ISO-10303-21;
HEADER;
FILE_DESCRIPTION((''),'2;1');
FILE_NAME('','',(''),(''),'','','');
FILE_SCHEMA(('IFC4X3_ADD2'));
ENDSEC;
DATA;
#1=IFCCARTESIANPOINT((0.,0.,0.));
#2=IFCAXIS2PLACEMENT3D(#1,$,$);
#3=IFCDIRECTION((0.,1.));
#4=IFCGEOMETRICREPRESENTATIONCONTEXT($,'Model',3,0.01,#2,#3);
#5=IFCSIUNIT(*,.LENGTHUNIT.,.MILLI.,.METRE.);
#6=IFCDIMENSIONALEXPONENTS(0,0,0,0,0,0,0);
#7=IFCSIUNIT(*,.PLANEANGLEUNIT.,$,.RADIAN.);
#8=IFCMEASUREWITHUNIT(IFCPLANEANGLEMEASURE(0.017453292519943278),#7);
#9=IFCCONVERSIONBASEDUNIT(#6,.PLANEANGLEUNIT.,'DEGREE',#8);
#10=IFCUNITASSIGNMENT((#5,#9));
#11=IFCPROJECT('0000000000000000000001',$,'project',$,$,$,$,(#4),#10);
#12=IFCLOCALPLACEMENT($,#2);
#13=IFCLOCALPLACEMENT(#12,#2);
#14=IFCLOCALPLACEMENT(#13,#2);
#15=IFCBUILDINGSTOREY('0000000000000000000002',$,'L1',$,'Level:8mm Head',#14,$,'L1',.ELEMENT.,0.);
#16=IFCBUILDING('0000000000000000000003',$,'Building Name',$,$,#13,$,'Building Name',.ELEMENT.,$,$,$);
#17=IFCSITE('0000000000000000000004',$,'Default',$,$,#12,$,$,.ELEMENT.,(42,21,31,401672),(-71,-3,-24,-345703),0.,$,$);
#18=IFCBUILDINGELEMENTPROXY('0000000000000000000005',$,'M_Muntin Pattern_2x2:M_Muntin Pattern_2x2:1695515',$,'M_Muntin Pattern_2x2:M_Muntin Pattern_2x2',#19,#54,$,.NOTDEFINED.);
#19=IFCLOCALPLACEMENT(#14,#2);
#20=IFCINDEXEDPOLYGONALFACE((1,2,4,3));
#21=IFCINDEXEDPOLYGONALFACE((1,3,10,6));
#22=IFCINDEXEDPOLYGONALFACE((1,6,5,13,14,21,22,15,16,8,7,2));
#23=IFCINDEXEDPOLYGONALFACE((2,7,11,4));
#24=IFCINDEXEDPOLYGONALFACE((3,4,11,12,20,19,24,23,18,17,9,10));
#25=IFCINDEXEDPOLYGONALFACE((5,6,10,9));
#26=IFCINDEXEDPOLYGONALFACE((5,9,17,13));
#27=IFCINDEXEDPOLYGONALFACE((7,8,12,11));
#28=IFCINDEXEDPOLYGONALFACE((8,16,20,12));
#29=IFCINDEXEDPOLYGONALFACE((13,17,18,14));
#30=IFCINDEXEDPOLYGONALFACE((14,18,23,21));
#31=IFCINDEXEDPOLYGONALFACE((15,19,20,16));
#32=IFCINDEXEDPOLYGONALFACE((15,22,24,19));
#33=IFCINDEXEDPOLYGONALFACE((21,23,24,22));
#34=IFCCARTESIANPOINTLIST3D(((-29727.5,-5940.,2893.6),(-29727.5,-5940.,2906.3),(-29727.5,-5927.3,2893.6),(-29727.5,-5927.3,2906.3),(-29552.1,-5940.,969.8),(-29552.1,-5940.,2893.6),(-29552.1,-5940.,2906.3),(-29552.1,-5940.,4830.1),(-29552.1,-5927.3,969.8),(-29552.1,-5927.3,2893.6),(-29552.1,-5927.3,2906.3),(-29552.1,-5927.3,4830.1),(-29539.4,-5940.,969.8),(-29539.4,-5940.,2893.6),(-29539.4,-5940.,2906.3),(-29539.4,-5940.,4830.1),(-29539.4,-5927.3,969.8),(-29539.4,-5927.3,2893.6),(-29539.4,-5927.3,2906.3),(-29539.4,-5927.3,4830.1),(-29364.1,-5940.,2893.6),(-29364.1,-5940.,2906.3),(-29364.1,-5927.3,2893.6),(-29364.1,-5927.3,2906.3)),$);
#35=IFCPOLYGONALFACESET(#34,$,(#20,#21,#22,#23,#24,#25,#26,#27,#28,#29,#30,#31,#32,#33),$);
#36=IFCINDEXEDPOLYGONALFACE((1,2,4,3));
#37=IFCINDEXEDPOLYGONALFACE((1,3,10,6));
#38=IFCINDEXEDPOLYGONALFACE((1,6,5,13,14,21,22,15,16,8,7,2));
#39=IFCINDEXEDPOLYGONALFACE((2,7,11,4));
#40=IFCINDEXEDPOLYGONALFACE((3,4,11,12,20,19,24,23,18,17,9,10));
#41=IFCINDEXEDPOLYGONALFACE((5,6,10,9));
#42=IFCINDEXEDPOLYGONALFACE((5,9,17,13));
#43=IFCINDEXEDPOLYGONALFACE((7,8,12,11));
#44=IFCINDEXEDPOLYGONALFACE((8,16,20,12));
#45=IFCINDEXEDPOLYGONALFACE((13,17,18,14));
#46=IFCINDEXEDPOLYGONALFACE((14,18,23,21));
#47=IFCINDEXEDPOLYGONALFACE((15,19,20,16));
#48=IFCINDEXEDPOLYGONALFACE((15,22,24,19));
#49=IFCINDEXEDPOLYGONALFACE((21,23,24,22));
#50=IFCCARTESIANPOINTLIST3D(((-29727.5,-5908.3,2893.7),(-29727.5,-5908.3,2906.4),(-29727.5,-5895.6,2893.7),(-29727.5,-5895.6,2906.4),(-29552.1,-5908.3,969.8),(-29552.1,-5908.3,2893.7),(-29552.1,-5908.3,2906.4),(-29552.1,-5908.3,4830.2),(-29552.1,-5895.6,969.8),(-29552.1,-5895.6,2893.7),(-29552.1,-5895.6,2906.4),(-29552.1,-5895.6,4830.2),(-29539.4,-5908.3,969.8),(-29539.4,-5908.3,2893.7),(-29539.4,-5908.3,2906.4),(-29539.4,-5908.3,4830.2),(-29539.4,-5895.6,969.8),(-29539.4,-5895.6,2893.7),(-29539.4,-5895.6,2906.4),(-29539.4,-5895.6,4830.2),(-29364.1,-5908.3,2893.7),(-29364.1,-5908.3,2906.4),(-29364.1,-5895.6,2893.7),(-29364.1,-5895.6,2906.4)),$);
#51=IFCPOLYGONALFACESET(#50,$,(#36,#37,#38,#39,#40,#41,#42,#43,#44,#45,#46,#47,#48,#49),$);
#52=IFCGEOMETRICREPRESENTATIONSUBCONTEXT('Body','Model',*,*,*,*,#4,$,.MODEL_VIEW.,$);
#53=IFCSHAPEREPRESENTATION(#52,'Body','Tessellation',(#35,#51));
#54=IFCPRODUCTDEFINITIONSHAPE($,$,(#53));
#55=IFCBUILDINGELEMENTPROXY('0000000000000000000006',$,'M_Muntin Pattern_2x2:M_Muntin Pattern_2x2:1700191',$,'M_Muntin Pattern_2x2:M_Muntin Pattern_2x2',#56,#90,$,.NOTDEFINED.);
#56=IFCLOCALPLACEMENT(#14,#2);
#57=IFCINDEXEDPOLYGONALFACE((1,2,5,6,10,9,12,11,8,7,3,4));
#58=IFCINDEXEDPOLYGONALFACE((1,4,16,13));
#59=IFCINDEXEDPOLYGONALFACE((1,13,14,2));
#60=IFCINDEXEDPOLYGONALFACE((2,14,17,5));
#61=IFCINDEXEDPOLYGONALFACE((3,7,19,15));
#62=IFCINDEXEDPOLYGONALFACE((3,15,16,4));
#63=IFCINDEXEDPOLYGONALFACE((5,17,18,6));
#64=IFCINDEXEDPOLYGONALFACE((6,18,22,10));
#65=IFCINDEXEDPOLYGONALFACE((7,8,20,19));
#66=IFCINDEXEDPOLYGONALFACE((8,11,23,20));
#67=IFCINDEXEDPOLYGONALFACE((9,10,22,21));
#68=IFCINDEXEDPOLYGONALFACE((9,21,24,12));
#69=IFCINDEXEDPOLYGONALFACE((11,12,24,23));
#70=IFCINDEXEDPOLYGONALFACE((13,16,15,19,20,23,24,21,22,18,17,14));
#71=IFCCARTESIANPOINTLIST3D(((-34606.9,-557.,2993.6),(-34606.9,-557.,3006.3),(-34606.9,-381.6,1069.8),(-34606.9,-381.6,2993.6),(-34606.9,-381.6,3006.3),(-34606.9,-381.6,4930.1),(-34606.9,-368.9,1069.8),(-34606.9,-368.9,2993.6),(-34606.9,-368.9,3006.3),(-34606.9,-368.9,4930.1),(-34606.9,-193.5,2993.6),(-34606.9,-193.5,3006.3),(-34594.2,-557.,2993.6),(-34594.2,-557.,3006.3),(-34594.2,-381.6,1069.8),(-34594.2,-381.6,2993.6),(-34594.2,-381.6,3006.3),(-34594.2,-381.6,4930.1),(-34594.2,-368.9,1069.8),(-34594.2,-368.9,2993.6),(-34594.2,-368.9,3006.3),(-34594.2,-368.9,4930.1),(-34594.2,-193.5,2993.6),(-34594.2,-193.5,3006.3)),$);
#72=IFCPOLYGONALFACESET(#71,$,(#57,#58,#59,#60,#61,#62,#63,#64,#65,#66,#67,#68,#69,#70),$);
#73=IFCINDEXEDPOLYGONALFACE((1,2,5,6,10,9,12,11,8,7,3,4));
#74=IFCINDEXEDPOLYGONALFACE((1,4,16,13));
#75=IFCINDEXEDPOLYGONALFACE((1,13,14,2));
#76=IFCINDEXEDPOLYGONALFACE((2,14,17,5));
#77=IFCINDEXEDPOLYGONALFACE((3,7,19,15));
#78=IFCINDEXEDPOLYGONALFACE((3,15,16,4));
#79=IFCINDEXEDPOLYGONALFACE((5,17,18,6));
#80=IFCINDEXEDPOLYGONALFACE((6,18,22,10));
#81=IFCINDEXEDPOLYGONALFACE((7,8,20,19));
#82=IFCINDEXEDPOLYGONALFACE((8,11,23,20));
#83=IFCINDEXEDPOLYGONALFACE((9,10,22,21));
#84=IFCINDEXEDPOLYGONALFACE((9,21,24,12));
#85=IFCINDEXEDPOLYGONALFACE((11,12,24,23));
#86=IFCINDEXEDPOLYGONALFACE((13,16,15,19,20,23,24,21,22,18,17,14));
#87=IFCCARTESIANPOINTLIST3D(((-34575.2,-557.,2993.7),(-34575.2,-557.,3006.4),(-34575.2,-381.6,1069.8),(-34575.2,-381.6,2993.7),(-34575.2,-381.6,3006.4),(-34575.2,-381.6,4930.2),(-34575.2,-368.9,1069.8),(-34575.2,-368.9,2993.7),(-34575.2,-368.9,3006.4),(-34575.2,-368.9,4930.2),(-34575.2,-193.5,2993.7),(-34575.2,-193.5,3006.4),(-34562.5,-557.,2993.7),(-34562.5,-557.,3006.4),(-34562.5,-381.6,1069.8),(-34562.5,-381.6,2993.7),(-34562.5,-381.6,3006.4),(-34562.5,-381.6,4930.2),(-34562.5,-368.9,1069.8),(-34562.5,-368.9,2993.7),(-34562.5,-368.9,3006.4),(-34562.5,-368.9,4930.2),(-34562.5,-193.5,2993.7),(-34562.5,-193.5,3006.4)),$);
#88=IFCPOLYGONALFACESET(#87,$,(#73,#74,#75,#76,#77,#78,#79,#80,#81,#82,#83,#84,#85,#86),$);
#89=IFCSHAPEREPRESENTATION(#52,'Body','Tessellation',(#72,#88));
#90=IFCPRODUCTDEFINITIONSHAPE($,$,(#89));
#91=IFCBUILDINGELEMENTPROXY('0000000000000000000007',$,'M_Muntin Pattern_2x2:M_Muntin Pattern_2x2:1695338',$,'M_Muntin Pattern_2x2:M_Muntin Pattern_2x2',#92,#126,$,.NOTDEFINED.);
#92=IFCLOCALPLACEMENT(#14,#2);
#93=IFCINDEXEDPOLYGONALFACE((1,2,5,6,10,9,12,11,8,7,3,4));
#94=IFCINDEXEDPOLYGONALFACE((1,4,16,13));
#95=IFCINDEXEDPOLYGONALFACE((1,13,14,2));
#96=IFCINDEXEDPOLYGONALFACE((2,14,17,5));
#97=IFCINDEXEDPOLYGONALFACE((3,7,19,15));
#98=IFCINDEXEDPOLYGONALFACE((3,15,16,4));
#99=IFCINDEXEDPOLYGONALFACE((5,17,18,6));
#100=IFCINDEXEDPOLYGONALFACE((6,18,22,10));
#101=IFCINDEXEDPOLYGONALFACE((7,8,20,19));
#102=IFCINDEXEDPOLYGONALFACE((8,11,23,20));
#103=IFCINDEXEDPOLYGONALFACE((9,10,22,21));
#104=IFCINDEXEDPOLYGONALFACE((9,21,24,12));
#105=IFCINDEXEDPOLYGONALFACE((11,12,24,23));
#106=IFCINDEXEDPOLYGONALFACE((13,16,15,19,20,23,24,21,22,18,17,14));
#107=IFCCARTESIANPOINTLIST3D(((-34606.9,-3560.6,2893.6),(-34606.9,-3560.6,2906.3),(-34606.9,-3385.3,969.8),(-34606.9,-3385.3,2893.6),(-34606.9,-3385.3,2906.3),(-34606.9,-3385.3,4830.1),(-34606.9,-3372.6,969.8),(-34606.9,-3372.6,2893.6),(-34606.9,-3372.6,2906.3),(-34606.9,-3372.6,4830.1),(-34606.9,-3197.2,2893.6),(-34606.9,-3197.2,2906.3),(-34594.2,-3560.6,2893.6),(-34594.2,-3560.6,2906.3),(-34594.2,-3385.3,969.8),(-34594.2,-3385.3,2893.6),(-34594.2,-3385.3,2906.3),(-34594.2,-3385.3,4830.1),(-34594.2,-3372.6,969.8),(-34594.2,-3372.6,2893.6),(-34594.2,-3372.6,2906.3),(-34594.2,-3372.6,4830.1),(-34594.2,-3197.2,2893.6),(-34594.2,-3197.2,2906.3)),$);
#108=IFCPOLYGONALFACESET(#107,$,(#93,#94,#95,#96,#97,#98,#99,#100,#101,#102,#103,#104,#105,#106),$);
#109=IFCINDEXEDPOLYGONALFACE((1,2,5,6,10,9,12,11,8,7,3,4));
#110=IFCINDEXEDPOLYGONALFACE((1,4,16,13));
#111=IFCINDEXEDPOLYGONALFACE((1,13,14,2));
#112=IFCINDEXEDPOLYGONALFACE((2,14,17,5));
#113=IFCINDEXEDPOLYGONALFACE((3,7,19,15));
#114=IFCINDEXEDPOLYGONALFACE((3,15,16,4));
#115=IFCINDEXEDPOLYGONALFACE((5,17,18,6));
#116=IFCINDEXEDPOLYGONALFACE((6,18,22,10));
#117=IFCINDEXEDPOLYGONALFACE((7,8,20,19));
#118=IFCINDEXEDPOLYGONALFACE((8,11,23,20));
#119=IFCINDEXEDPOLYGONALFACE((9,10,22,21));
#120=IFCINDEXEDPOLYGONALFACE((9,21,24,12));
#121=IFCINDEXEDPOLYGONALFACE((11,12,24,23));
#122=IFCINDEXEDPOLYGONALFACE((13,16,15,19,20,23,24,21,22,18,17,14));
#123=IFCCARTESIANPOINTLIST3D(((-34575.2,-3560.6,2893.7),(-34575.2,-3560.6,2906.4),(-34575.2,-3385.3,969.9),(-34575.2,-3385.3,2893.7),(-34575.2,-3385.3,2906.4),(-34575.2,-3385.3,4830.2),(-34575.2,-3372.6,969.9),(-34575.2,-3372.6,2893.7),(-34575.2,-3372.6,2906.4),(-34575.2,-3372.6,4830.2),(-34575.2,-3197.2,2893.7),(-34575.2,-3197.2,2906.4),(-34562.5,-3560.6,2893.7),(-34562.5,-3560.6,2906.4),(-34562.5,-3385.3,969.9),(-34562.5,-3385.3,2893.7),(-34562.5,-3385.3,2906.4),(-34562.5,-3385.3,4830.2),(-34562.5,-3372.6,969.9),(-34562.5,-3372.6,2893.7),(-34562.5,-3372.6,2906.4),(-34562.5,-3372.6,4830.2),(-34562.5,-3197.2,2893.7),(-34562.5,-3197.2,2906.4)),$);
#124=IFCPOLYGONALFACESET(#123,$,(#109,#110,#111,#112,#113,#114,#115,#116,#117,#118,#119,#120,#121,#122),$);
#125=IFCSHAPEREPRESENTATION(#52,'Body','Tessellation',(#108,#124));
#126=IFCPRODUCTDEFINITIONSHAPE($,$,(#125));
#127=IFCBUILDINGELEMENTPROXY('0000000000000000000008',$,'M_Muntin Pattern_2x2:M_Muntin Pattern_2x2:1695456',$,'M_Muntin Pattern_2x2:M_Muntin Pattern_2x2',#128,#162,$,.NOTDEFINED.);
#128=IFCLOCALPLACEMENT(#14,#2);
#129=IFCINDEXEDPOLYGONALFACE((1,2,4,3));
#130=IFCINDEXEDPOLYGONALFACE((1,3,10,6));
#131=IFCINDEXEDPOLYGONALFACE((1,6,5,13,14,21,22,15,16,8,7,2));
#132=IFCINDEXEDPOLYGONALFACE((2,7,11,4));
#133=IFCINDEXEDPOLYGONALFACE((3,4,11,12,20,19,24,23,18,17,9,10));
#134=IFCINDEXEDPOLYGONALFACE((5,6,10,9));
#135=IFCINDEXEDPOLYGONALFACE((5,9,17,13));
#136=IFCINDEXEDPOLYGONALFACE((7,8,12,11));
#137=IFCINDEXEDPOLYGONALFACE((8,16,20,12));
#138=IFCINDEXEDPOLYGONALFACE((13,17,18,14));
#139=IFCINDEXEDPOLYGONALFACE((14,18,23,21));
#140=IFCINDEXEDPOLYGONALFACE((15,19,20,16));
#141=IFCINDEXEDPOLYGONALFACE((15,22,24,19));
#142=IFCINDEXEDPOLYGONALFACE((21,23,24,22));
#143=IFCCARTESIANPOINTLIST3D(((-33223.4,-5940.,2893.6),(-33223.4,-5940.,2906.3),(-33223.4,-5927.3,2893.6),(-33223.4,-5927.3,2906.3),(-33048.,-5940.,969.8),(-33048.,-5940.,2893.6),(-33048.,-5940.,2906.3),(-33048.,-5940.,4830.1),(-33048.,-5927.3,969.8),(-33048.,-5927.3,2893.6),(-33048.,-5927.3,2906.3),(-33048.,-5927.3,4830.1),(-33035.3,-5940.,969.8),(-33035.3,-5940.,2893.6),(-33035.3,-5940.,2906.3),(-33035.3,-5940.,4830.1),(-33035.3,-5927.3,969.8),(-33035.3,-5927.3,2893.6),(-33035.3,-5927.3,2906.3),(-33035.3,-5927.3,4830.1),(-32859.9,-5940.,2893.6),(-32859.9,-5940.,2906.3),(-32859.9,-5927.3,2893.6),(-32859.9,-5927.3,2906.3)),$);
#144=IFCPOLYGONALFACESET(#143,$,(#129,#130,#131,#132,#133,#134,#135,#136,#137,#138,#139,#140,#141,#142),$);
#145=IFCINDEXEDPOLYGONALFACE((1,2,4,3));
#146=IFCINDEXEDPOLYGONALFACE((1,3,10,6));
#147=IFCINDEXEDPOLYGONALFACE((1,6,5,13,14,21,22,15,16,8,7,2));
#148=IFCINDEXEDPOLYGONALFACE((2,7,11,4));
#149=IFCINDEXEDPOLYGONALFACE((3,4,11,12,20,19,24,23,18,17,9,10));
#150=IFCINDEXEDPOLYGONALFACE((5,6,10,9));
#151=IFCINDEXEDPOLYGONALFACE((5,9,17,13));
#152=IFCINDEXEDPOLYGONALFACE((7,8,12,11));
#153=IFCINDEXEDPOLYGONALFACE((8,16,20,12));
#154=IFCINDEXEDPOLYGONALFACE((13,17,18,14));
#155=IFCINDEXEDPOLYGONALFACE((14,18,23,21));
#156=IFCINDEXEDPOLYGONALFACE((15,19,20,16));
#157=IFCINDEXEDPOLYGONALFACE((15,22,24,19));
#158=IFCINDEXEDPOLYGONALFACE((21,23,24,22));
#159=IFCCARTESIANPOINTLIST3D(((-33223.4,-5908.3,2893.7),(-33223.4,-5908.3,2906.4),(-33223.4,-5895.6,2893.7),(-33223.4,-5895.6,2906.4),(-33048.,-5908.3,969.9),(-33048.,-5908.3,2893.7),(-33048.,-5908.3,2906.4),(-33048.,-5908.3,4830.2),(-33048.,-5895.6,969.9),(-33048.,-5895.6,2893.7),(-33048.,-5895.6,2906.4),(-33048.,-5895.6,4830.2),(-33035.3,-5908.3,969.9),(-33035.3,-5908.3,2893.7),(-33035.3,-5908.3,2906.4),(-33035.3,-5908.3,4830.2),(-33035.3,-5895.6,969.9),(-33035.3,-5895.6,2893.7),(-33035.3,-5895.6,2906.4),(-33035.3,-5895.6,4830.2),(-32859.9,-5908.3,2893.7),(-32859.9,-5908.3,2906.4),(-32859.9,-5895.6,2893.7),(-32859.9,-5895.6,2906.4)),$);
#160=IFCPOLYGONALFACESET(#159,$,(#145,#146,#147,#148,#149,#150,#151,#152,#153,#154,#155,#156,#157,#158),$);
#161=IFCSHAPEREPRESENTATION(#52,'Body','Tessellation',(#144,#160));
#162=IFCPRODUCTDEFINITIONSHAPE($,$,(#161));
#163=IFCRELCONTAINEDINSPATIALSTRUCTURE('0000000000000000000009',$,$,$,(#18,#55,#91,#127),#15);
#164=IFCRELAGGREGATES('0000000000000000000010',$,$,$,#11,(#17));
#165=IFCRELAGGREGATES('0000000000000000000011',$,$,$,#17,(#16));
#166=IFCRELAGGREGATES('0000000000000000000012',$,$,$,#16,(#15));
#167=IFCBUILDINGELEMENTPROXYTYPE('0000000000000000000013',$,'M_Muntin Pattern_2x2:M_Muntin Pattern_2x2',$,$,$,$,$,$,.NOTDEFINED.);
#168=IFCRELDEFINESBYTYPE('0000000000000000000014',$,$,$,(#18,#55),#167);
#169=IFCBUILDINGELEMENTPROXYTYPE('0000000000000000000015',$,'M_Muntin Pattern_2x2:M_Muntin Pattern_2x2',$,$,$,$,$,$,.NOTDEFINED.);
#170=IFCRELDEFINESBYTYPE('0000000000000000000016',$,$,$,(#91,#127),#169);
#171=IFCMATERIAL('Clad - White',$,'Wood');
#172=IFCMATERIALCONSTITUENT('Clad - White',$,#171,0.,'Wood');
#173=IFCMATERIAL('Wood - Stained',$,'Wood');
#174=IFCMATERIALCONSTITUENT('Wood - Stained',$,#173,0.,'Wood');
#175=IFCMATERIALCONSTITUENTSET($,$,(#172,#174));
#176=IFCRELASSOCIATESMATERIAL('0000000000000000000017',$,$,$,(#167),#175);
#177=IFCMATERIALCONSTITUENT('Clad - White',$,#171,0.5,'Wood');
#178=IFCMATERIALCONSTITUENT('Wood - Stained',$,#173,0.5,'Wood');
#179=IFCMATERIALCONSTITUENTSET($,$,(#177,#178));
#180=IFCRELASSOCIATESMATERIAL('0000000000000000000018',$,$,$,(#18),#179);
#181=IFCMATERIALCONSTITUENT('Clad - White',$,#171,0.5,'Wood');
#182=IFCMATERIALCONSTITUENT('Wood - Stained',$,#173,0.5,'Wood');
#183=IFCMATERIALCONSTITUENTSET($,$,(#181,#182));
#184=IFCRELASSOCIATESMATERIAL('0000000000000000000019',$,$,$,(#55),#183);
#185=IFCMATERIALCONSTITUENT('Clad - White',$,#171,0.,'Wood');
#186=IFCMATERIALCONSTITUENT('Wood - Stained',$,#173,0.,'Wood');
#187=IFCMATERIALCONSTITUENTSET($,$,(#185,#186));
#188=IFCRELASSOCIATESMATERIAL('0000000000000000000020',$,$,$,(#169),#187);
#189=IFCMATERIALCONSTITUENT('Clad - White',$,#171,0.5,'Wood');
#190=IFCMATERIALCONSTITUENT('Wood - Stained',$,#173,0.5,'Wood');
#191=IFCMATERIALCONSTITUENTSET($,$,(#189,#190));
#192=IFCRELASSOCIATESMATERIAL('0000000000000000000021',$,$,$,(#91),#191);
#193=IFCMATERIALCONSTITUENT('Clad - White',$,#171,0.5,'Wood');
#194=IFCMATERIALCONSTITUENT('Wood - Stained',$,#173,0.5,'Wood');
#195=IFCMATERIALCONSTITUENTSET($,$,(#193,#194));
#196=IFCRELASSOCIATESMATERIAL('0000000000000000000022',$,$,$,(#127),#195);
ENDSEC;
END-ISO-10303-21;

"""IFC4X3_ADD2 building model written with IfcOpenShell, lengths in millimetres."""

from ifc_helpers import new_model, entity, si_unit, converted_unit, direction, frame, origin, place, context, subcontext, project, spatial, polyline, outline, extrude, source, transform, mapped, material, constituent, constituent_set, type_object, type_shapes, element, save


model = new_model("IFC4X3_ADD2")

# Units and contexts
model_context = context("Model", 3, precision=0.01, world=origin(), true_north=direction((0.0, 1.0)))
body_context = subcontext(model_context, "Body", "Model", "MODEL_VIEW")
ifc_project = project(units=[si_unit("LENGTHUNIT", "METRE", prefix="MILLI"), converted_unit("PLANEANGLEUNIT", "DEGREE", entity("IfcPlaneAngleMeasure", 0.017453292519943278), si_unit("PLANEANGLEUNIT", "RADIAN"), dimensions=[0, 0, 0, 0, 0, 0, 0])], contexts=[model_context])

# Site, building, storey
site_placement = place(None, origin())
site = spatial("IfcSite", under=ifc_project, at=site_placement, Name="Default", CompositionType="ELEMENT", RefLatitude=(42, 21, 31, 401672), RefLongitude=(-71, -3, -24, -345703), RefElevation=0.0)
building_placement = place(site_placement, origin())
building = spatial("IfcBuilding", under=site, at=building_placement, Name="Building Name", LongName="Building Name", CompositionType="ELEMENT")
storey_placement = place(building_placement, origin())
storey = spatial("IfcBuildingStorey", under=building, at=storey_placement, Name="L1", ObjectType="Level:8mm Head", LongName="L1", CompositionType="ELEMENT", Elevation=0.0)

# Building element proxies
ifc_material_1 = material(Name="Clad - White", Category="Wood")
ifc_material_2 = material(Name="Wood - Stained", Category="Wood")
ifc_constituent_1 = constituent(ifc_material_1, Name="Clad - White", Category="Wood", fraction=0.0)
ifc_constituent_2 = constituent(ifc_material_2, Name="Wood - Stained", Category="Wood", fraction=0.0)
ifc_constituent_set_1 = constituent_set(constituents=[ifc_constituent_1, ifc_constituent_2])
building_element_proxy_type_1 = type_object("IfcBuildingElementProxyType", Name="M_Muntin Pattern_2x2:M_Muntin Pattern_2x2", PredefinedType="NOTDEFINED", material=ifc_constituent_set_1)
shared_shape_1 = source(origin(), body_context, "Body", "SweptSolid", [
    extrude(outline(polyline([(6.4, -6.4), (1930.1, -6.4), (1930.1, 6.3), (6.4, 6.3), (6.4, 181.7), (-6.3, 181.7), (-6.3, 6.3), (-1930.2, 6.3), (-1930.2, -6.4), (-6.3, -6.4), (-6.3, -181.7), (6.4, -181.7), (6.4, -6.4)])), frame((0.0, 9.5, 1930.1), z_axis=(0.0, 1.0, 0.0), x_axis=(0.0, 0.0, 1.0)), (0.0, 0.0, 1.0), 12.7),
    extrude(outline(polyline([(6.4, -6.4), (1930.2, -6.4), (1930.2, 6.3), (6.4, 6.3), (6.4, 181.7), (-6.3, 181.7), (-6.3, 6.3), (-1930.2, 6.3), (-1930.2, -6.4), (-6.3, -6.4), (-6.3, -181.7), (6.4, -181.7), (6.4, -6.4)])), frame((0.0, -22.2, 1930.2), z_axis=(0.0, 1.0, 0.0), x_axis=(0.0, 0.0, 1.0)), (0.0, 0.0, 1.0), 12.7),
])
type_shapes(building_element_proxy_type_1, [shared_shape_1])
ifc_constituent_3 = constituent(ifc_material_1, Name="Clad - White", Category="Wood", fraction=0.5)
ifc_constituent_4 = constituent(ifc_material_2, Name="Wood - Stained", Category="Wood", fraction=0.5)
ifc_constituent_set_2 = constituent_set(constituents=[ifc_constituent_3, ifc_constituent_4])
proxy_1_placement = place(storey_placement, frame((-29545.8, -5917.8, 969.8), z_axis=(0.0, 0.0, 1.0), x_axis=(-1.0, 0.0, 0.0)))
element("IfcBuildingElementProxy", 1, at=proxy_1_placement, inside=storey, type_object=building_element_proxy_type_1, material=ifc_constituent_set_2, Name="M_Muntin Pattern_2x2:M_Muntin Pattern_2x2:1695515", ObjectType="M_Muntin Pattern_2x2:M_Muntin Pattern_2x2", PredefinedType="NOTDEFINED", context=body_context, shape_type="MappedRepresentation", body=[
    mapped(shared_shape_1, transform((0.0, 0.0, 0.0), scale=1.0)),
])
ifc_constituent_5 = constituent(ifc_material_1, Name="Clad - White", Category="Wood", fraction=0.5)
ifc_constituent_6 = constituent(ifc_material_2, Name="Wood - Stained", Category="Wood", fraction=0.5)
ifc_constituent_set_3 = constituent_set(constituents=[ifc_constituent_5, ifc_constituent_6])
proxy_2_placement = place(storey_placement, frame((-34584.7, -375.2, 1069.8), z_axis=(0.0, 0.0, 1.0), x_axis=(0.0, 1.0, 0.0)))
element("IfcBuildingElementProxy", 2, at=proxy_2_placement, inside=storey, type_object=building_element_proxy_type_1, material=ifc_constituent_set_3, Name="M_Muntin Pattern_2x2:M_Muntin Pattern_2x2:1700191", ObjectType="M_Muntin Pattern_2x2:M_Muntin Pattern_2x2", PredefinedType="NOTDEFINED", context=body_context, shape_type="MappedRepresentation", body=[
    mapped(shared_shape_1, transform((0.0, 0.0, 0.0), scale=1.0)),
])
ifc_constituent_7 = constituent(ifc_material_1, Name="Clad - White", Category="Wood", fraction=0.5)
ifc_constituent_8 = constituent(ifc_material_2, Name="Wood - Stained", Category="Wood", fraction=0.5)
ifc_constituent_set_4 = constituent_set(constituents=[ifc_constituent_7, ifc_constituent_8])
ifc_constituent_9 = constituent(ifc_material_1, Name="Clad - White", Category="Wood", fraction=0.0)
ifc_constituent_10 = constituent(ifc_material_2, Name="Wood - Stained", Category="Wood", fraction=0.0)
ifc_constituent_set_5 = constituent_set(constituents=[ifc_constituent_9, ifc_constituent_10])
building_element_proxy_type_2 = type_object("IfcBuildingElementProxyType", Name="M_Muntin Pattern_2x2:M_Muntin Pattern_2x2", PredefinedType="NOTDEFINED", material=ifc_constituent_set_5)
shared_shape_2 = source(origin(), body_context, "Body", "SweptSolid", [
    extrude(outline(polyline([(6.4, -6.4), (1930.1, -6.4), (1930.1, 6.3), (6.4, 6.3), (6.4, 181.7), (-6.3, 181.7), (-6.3, 6.3), (-1930.2, 6.3), (-1930.2, -6.4), (-6.3, -6.4), (-6.3, -181.7), (6.4, -181.7), (6.4, -6.4)])), frame((0.0, -22.2, 1930.1), z_axis=(0.0, 1.0, 0.0), x_axis=(0.0, 0.0, 1.0)), (0.0, 0.0, 1.0), 12.7),
    extrude(outline(polyline([(6.4, -6.4), (1930.2, -6.4), (1930.2, 6.3), (6.4, 6.3), (6.4, 181.7), (-6.3, 181.7), (-6.3, 6.3), (-1930.2, 6.3), (-1930.2, -6.4), (-6.3, -6.4), (-6.3, -181.7), (6.4, -181.7), (6.4, -6.4)])), frame((0.0, 9.5, 1930.2), z_axis=(0.0, 1.0, 0.0), x_axis=(0.0, 0.0, 1.0)), (0.0, 0.0, 1.0), 12.7),
])
type_shapes(building_element_proxy_type_2, [shared_shape_2])
proxy_3_placement = place(storey_placement, frame((-34584.7, -3378.9, 969.9), z_axis=(0.0, 0.0, 1.0), x_axis=(0.0, -1.0, 0.0)))
element("IfcBuildingElementProxy", 3, at=proxy_3_placement, inside=storey, type_object=building_element_proxy_type_2, material=ifc_constituent_set_4, Name="M_Muntin Pattern_2x2:M_Muntin Pattern_2x2:1695338", ObjectType="M_Muntin Pattern_2x2:M_Muntin Pattern_2x2", PredefinedType="NOTDEFINED", context=body_context, shape_type="MappedRepresentation", body=[
    mapped(shared_shape_2, transform((0.0, 0.0, 0.0), scale=1.0)),
])
ifc_constituent_11 = constituent(ifc_material_1, Name="Clad - White", Category="Wood", fraction=0.5)
ifc_constituent_12 = constituent(ifc_material_2, Name="Wood - Stained", Category="Wood", fraction=0.5)
ifc_constituent_set_6 = constituent_set(constituents=[ifc_constituent_11, ifc_constituent_12])
proxy_4_placement = place(storey_placement, frame((-33041.6, -5917.8, 969.9)))
element("IfcBuildingElementProxy", 4, at=proxy_4_placement, inside=storey, type_object=building_element_proxy_type_2, material=ifc_constituent_set_6, Name="M_Muntin Pattern_2x2:M_Muntin Pattern_2x2:1695456", ObjectType="M_Muntin Pattern_2x2:M_Muntin Pattern_2x2", PredefinedType="NOTDEFINED", context=body_context, shape_type="MappedRepresentation", body=[
    mapped(shared_shape_2, transform((0.0, 0.0, 0.0), scale=1.0)),
])

save(model, "model.ifc")
